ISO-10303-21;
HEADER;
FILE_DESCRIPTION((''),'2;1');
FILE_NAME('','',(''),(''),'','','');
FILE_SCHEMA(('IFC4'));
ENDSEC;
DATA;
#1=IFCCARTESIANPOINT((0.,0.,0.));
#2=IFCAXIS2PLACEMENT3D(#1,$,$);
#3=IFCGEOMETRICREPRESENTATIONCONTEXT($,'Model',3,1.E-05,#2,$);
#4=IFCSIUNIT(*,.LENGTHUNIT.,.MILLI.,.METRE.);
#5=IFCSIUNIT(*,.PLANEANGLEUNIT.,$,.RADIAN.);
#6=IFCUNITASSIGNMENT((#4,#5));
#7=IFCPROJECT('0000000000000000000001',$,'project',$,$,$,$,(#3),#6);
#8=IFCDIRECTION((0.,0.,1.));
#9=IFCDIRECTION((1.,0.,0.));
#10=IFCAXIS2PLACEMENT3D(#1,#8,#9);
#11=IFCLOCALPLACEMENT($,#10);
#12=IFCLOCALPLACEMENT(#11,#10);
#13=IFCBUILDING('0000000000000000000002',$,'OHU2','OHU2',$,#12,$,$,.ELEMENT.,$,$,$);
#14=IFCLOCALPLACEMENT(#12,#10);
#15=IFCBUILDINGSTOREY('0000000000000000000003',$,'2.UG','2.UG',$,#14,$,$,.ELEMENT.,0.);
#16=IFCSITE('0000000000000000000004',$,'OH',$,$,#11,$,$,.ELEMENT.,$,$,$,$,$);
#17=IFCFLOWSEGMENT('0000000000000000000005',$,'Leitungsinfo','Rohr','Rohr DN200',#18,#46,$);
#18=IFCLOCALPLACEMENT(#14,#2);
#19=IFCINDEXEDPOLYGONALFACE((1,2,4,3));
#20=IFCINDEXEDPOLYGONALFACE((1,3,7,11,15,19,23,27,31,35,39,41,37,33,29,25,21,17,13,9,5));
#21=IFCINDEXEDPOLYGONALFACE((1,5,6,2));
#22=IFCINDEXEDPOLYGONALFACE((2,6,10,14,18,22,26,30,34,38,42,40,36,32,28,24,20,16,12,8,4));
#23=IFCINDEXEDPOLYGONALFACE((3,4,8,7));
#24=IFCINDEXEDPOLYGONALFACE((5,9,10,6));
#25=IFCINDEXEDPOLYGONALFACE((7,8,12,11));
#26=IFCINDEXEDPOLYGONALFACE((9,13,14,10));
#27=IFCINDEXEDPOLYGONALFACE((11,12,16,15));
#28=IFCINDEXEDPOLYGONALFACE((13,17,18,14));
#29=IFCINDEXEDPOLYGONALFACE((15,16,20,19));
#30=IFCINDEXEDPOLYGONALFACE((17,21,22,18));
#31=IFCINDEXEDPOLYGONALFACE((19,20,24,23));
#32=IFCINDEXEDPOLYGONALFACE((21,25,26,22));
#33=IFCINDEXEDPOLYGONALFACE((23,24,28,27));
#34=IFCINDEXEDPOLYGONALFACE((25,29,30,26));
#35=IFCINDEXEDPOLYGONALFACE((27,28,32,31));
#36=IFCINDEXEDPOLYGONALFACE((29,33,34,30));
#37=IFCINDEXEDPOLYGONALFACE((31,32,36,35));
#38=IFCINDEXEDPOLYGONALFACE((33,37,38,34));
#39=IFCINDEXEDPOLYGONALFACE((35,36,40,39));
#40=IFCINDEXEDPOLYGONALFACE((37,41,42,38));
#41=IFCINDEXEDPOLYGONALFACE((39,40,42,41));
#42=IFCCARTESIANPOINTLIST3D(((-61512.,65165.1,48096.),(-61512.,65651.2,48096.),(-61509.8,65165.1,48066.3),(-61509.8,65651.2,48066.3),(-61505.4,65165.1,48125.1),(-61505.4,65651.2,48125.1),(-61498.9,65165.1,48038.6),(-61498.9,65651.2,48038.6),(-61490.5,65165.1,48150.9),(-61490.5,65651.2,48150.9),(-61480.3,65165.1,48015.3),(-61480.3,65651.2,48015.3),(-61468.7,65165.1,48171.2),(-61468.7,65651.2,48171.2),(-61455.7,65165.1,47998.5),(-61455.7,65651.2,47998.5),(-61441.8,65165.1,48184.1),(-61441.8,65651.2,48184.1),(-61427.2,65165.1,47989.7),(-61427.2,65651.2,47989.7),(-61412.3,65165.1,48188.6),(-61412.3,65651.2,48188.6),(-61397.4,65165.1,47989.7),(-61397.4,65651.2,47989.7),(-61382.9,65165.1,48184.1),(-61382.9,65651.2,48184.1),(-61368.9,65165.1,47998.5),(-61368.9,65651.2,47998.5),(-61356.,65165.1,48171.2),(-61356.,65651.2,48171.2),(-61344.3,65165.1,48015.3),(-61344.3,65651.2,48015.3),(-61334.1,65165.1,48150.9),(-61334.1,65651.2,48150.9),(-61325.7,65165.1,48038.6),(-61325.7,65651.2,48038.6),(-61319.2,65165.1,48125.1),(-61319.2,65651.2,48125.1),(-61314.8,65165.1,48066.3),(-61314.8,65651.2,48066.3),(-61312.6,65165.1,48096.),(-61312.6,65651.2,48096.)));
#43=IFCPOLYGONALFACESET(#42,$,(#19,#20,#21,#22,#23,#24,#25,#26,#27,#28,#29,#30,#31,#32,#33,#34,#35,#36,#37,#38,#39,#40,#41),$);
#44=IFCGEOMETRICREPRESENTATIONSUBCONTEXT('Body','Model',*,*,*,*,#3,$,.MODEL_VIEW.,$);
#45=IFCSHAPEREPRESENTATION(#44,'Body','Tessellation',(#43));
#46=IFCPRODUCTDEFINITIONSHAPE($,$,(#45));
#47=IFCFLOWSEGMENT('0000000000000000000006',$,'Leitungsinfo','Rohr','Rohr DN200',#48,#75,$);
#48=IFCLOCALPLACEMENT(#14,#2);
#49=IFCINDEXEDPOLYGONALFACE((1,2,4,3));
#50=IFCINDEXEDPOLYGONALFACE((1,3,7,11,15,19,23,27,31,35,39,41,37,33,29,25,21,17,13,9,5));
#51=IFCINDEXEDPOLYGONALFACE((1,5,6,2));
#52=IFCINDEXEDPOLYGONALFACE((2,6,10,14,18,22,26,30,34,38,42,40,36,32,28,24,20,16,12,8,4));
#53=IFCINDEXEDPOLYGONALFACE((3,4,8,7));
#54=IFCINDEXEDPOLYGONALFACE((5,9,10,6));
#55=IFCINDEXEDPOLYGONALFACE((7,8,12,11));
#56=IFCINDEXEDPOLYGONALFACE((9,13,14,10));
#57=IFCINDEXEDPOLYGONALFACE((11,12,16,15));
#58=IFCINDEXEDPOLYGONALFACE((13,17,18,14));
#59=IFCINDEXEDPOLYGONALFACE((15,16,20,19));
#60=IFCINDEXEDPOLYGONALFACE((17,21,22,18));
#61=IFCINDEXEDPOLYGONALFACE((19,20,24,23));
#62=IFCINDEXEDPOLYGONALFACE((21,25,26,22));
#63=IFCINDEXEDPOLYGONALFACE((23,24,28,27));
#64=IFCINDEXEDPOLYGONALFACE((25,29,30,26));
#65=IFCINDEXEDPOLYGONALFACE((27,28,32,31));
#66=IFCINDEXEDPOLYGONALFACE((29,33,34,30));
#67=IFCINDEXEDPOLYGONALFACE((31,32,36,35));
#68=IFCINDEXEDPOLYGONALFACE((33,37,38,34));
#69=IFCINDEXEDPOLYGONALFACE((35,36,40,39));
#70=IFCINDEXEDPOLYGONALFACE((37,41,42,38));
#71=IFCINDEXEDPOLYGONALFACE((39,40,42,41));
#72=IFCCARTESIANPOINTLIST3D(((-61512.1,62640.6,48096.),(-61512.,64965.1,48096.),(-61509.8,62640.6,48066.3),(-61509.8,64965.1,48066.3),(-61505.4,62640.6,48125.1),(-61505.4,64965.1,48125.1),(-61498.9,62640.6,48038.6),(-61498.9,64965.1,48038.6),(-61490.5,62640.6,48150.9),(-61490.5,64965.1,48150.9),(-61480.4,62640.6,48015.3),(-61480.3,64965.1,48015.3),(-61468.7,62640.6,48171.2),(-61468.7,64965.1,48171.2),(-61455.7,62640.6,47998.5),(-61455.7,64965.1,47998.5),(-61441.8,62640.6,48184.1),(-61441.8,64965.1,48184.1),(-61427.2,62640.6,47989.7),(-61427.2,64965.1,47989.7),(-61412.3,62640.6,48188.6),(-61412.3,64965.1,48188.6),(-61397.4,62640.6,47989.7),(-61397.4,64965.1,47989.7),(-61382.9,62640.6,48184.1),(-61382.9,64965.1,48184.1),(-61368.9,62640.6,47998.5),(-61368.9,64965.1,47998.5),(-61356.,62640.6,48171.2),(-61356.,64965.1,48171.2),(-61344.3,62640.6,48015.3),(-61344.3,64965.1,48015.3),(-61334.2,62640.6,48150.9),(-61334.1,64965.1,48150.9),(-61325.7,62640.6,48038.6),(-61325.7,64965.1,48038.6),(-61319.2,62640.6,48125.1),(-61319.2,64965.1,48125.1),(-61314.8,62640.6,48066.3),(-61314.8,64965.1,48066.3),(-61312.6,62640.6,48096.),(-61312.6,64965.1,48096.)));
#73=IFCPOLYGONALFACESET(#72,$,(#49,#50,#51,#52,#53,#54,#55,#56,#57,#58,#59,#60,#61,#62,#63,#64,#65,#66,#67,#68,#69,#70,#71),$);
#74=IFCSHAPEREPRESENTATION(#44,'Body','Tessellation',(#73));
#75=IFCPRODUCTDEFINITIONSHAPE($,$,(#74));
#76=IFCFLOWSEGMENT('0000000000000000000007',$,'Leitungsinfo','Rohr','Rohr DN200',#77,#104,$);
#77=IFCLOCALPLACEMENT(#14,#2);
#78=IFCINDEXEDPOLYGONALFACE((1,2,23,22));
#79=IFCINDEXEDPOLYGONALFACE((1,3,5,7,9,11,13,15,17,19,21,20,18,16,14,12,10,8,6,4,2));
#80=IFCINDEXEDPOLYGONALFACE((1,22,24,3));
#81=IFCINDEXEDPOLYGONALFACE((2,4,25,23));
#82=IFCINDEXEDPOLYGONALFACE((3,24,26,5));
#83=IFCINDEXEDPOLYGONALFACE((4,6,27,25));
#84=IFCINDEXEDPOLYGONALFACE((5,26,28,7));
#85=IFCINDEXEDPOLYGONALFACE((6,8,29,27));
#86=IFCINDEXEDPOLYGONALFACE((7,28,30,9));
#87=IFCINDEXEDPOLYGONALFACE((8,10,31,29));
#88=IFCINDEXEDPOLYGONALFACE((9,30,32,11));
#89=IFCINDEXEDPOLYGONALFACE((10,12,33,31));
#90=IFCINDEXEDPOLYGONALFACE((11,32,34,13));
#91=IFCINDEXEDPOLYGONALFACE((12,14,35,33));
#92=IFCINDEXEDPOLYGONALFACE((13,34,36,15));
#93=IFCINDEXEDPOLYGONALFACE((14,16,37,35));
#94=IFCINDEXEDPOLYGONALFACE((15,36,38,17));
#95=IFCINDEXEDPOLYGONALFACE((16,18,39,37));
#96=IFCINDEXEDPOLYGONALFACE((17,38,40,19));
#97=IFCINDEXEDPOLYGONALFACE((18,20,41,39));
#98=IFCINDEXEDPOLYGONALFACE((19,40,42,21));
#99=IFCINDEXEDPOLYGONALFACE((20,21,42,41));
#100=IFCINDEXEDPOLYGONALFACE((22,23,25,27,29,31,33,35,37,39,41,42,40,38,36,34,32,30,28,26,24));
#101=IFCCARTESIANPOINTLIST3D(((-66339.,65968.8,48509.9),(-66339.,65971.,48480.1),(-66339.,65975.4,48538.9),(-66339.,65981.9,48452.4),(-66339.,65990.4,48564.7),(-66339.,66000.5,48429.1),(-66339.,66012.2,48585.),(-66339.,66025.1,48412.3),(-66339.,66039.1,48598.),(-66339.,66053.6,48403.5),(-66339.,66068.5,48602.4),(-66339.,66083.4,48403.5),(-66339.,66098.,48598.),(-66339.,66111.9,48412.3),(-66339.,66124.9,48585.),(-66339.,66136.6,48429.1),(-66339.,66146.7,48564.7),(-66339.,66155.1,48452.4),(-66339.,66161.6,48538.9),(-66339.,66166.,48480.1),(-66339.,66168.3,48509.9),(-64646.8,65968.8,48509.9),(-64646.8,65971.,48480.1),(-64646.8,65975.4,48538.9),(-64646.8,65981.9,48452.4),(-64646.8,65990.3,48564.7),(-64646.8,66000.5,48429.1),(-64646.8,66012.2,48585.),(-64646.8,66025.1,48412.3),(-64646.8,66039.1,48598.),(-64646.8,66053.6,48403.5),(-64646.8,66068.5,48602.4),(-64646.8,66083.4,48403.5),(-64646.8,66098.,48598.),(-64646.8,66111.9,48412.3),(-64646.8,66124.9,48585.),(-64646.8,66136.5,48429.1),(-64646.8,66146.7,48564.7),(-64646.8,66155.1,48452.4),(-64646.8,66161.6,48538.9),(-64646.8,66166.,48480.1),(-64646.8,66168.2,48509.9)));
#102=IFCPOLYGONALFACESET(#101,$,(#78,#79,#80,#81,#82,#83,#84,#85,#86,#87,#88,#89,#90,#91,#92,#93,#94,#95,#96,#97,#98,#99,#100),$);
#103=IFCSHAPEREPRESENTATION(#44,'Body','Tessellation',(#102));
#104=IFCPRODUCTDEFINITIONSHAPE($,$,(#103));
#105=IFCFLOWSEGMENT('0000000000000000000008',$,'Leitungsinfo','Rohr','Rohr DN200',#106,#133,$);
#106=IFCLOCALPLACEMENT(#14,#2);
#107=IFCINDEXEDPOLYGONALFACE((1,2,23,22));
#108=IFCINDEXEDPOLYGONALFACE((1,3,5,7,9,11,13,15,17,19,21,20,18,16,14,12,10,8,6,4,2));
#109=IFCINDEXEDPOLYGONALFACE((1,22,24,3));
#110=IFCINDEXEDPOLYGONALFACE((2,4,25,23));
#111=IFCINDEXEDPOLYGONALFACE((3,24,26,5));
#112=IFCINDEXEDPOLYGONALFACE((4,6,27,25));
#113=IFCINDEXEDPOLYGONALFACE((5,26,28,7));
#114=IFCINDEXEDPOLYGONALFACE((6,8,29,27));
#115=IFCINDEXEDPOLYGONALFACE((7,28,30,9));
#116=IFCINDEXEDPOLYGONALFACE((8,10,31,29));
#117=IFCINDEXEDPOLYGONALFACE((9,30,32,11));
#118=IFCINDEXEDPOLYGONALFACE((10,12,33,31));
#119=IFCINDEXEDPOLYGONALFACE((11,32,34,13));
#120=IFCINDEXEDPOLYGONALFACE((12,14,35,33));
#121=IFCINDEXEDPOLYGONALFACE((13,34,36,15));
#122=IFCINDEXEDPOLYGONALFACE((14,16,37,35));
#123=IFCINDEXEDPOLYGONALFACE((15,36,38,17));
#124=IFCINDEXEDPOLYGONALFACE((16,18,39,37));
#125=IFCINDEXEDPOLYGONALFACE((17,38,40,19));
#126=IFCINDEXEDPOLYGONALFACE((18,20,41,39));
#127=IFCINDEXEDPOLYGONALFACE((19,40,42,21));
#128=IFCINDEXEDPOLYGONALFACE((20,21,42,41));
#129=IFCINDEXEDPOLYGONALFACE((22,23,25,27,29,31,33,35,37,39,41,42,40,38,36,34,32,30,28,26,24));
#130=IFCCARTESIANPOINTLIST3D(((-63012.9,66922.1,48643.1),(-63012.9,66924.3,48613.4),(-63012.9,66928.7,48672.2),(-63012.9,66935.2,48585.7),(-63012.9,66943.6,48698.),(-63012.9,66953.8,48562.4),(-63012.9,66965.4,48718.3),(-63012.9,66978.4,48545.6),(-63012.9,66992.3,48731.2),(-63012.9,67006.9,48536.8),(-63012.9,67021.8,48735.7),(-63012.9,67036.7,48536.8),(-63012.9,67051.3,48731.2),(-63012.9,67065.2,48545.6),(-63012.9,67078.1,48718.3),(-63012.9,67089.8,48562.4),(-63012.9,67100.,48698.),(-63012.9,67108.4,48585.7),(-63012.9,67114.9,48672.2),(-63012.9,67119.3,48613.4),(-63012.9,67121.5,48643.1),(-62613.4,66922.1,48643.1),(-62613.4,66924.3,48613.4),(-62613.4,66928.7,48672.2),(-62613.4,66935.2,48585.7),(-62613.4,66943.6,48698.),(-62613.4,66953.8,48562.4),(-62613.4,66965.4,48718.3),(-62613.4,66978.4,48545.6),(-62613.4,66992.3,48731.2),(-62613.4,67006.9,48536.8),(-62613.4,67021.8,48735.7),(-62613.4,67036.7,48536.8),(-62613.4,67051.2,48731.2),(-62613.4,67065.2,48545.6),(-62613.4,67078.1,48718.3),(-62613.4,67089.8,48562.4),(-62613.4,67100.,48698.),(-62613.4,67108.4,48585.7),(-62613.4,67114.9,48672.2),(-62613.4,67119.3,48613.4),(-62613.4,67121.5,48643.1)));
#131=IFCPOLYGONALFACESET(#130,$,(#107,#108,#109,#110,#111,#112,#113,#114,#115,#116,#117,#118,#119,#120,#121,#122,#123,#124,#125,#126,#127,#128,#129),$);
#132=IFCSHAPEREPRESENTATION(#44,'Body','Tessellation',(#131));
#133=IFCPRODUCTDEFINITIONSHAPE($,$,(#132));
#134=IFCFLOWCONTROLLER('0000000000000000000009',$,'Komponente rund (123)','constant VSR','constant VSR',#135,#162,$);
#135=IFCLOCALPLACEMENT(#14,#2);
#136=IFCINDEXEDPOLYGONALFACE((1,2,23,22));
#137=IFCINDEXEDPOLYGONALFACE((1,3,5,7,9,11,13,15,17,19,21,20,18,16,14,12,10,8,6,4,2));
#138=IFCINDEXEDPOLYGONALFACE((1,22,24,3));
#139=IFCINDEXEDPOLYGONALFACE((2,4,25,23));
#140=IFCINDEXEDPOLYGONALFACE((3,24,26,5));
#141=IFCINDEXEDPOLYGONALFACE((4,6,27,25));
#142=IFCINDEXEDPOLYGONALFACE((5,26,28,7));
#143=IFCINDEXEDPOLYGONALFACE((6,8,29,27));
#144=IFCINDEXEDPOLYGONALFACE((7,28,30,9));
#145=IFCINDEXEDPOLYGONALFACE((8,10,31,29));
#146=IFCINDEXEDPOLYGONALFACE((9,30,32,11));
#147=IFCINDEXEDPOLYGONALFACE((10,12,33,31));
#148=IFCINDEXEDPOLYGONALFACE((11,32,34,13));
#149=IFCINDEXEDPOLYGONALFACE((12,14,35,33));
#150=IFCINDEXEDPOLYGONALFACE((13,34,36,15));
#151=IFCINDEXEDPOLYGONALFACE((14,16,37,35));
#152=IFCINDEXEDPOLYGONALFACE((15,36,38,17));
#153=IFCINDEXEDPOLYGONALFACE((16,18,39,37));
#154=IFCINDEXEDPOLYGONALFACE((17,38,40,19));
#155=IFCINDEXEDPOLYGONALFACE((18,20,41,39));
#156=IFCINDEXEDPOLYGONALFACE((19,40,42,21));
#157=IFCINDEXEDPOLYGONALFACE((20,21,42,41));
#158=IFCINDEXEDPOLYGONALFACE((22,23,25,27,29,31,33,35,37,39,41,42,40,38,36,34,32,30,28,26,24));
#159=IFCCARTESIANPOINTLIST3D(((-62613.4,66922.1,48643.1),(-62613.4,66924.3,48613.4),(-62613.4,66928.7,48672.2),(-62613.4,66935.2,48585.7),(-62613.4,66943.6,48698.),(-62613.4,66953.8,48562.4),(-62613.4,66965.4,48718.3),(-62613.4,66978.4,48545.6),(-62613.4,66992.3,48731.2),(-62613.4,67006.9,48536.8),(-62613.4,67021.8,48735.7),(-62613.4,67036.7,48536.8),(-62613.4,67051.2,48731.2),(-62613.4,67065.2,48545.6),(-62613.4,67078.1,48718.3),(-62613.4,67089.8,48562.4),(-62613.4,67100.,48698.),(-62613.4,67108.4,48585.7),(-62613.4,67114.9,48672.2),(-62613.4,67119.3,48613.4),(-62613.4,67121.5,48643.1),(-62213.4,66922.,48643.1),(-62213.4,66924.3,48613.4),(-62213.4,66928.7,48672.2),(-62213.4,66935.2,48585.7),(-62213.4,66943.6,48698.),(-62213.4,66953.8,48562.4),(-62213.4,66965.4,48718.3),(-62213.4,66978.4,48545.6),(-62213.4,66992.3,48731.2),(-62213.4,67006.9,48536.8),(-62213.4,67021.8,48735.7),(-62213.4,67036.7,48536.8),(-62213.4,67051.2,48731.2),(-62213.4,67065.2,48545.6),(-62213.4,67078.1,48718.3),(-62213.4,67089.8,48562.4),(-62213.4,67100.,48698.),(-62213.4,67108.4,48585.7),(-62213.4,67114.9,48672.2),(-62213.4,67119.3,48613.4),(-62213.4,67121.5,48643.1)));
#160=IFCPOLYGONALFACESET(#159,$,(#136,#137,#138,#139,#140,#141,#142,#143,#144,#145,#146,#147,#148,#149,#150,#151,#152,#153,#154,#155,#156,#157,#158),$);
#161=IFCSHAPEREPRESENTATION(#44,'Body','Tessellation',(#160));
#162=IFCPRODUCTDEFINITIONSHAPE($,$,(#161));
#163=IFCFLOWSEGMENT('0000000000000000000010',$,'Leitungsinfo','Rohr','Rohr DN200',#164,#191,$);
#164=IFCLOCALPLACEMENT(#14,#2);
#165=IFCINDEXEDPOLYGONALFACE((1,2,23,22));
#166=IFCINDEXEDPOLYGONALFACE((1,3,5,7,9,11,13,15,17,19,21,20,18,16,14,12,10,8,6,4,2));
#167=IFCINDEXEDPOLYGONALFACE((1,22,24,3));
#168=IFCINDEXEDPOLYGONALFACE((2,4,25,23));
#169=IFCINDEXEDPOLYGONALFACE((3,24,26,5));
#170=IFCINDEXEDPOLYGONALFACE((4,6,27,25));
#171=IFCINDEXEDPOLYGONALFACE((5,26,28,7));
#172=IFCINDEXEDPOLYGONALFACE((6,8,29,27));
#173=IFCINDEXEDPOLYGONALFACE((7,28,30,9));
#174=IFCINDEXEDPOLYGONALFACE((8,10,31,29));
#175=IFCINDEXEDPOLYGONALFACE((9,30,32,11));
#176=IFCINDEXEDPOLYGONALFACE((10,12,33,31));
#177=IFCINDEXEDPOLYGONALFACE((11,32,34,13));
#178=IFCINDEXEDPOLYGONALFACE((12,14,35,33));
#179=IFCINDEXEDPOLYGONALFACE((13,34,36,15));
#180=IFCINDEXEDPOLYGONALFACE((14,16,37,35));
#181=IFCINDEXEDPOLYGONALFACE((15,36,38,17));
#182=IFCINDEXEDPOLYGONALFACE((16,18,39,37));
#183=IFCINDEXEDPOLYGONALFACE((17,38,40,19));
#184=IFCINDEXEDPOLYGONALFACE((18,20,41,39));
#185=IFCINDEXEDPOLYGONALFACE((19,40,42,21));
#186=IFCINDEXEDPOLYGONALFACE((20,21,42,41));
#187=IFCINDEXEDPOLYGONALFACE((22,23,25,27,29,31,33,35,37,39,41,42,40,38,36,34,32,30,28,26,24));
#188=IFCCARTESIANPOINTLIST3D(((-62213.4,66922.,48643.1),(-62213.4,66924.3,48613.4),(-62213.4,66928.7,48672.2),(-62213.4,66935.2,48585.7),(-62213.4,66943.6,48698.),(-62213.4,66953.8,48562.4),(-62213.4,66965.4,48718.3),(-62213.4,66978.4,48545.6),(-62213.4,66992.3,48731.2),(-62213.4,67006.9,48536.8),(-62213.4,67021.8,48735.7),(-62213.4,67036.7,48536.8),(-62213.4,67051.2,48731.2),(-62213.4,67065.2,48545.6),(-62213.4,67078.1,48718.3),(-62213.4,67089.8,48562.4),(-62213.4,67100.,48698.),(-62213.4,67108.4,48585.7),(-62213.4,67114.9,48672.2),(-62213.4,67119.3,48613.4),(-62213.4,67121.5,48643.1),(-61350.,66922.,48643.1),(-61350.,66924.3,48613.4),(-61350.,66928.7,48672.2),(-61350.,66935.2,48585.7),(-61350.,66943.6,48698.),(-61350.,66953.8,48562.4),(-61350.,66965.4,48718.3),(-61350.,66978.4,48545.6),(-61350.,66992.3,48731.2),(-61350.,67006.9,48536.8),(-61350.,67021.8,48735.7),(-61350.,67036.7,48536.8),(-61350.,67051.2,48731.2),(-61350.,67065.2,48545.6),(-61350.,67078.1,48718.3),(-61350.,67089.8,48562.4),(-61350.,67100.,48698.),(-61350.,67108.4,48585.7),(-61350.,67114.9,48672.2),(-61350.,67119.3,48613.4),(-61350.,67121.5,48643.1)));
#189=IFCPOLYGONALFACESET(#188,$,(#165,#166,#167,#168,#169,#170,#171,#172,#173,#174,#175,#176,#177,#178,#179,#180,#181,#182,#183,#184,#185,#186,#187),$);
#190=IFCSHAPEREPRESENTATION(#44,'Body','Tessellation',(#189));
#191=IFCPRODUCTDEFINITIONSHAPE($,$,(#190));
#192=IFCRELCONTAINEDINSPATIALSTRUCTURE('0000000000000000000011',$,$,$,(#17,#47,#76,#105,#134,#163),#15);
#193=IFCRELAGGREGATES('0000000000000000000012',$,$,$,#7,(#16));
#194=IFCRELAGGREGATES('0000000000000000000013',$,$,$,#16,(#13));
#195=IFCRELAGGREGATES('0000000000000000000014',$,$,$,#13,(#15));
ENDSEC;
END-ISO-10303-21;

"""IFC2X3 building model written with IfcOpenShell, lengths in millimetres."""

from ifc_helpers import new_model, si_unit, frame, origin, origin_with_axes, origin_2d_with_axis, place, context, subcontext, project, spatial, circle, extrude, element, save


model = new_model("IFC2X3")

# Units and contexts
model_context = context("Model", 3, precision=1e-05, world=origin())
body_context = subcontext(model_context, "Body", "Model", "MODEL_VIEW")
ifc_project = project(units=[si_unit("LENGTHUNIT", "METRE", prefix="MILLI"), si_unit("PLANEANGLEUNIT", "RADIAN")], contexts=[model_context])

# Site, building, storey
site_placement = place(None, origin_with_axes())
site = spatial("IfcSite", under=ifc_project, at=site_placement, Name="OH", CompositionType="ELEMENT")
building_placement = place(site_placement, origin_with_axes())
building = spatial("IfcBuilding", under=site, at=building_placement, Name="OHU2", Description="OHU2", CompositionType="ELEMENT")
storey_placement = place(building_placement, origin_with_axes())
storey = spatial("IfcBuildingStorey", under=building, at=storey_placement, Name="2.UG", Description="2.UG", CompositionType="ELEMENT", Elevation=0.0)

# Flow segments
flow_segment_1_placement = place(storey_placement, frame((-61412.3, 65408.2, 48088.6), z_axis=(0.0, 0.0, 1.0), x_axis=(1.0, 0.0, 0.0)))
element("IfcFlowSegment", 1, at=flow_segment_1_placement, inside=storey, Name="Leitungsinfo", Description="Rohr", ObjectType="Rohr DN200", context=body_context, shape_type="SweptSolid", body=[
    extrude(circle(Radius=100.0, at=origin_2d_with_axis()), frame((0.0, 243.1, 0.0), z_axis=(-0.000003, -1.0, 0.0), x_axis=(0.0, 0.0, 1.0)), (0.0, 0.0, 1.0), 486.1),
])
flow_segment_2_placement = place(storey_placement, frame((-61412.3, 63802.8, 48088.6), z_axis=(0.0, 0.0, 1.0), x_axis=(1.0, 0.0, 0.0)))
element("IfcFlowSegment", 2, at=flow_segment_2_placement, inside=storey, Name="Leitungsinfo", Description="Rohr", ObjectType="Rohr DN200", context=body_context, shape_type="SweptSolid", body=[
    extrude(circle(Radius=100.0, at=origin_2d_with_axis()), frame((0.0, 1162.3, 0.0), z_axis=(-0.000003, -1.0, 0.0), x_axis=(0.0, 0.0, 1.0)), (0.0, 0.0, 1.0), 2324.5),
])
flow_segment_3_placement = place(storey_placement, frame((-65492.9, 66068.7, 48502.4), z_axis=(0.0, 0.0, 1.0), x_axis=(1.0, 0.0, 0.0)))
element("IfcFlowSegment", 3, at=flow_segment_3_placement, inside=storey, Name="Leitungsinfo", Description="Rohr", ObjectType="Rohr DN200", context=body_context, shape_type="SweptSolid", body=[
    extrude(circle(Radius=100.0, at=origin_2d_with_axis()), frame((-846.1, -0.1, 0.0), z_axis=(1.0, -0.000003, 0.0), x_axis=(0.0, 0.0, 1.0)), (0.0, 0.0, 1.0), 1692.2),
])
flow_segment_4_placement = place(storey_placement, frame((-62813.2, 67021.9, 48635.7), z_axis=(0.0, 0.0, 1.0), x_axis=(1.0, 0.0, 0.0)))
element("IfcFlowSegment", 4, at=flow_segment_4_placement, inside=storey, Name="Leitungsinfo", Description="Rohr", ObjectType="Rohr DN200", context=body_context, shape_type="SweptSolid", body=[
    extrude(circle(Radius=100.0, at=origin_2d_with_axis()), frame((-199.8, -0.1, 0.0), z_axis=(1.0, -0.000025, 0.0), x_axis=(0.0, 0.0, 1.0)), (0.0, 0.0, 1.0), 399.5),
])

# Flow controller
flow_controller_placement = place(storey_placement, frame((-62413.4, 67021.8, 48635.7), z_axis=(0.0, 0.0, 1.0), x_axis=(1.0, 0.0, 0.0)))
element("IfcFlowController", 5, at=flow_controller_placement, inside=storey, Name="Komponente rund (123)", Description="constant VSR", ObjectType="constant VSR", context=body_context, shape_type="SweptSolid", body=[
    extrude(circle(Radius=100.0, at=origin_2d_with_axis()), frame((-200.0, 0.0, 0.0), z_axis=(1.0, -0.000003, 0.0), x_axis=(0.0, 0.0, 1.0)), (0.0, 0.0, 1.0), 400.0),
])

# Flow segment
flow_segment_5_placement = place(storey_placement, frame((-61781.7, 67021.9, 48635.7), z_axis=(0.0, 0.0, 1.0), x_axis=(1.0, 0.0, 0.0)))
element("IfcFlowSegment", 6, at=flow_segment_5_placement, inside=storey, Name="Leitungsinfo", Description="Rohr", ObjectType="Rohr DN200", context=body_context, shape_type="SweptSolid", body=[
    extrude(circle(Radius=100.0, at=origin_2d_with_axis()), frame((-431.7, -0.2, 0.0), z_axis=(1.0, 0.000002, 0.0), x_axis=(0.0, 0.0, 1.0)), (0.0, 0.0, 1.0), 863.4),
])

save(model, "model.ifc")
